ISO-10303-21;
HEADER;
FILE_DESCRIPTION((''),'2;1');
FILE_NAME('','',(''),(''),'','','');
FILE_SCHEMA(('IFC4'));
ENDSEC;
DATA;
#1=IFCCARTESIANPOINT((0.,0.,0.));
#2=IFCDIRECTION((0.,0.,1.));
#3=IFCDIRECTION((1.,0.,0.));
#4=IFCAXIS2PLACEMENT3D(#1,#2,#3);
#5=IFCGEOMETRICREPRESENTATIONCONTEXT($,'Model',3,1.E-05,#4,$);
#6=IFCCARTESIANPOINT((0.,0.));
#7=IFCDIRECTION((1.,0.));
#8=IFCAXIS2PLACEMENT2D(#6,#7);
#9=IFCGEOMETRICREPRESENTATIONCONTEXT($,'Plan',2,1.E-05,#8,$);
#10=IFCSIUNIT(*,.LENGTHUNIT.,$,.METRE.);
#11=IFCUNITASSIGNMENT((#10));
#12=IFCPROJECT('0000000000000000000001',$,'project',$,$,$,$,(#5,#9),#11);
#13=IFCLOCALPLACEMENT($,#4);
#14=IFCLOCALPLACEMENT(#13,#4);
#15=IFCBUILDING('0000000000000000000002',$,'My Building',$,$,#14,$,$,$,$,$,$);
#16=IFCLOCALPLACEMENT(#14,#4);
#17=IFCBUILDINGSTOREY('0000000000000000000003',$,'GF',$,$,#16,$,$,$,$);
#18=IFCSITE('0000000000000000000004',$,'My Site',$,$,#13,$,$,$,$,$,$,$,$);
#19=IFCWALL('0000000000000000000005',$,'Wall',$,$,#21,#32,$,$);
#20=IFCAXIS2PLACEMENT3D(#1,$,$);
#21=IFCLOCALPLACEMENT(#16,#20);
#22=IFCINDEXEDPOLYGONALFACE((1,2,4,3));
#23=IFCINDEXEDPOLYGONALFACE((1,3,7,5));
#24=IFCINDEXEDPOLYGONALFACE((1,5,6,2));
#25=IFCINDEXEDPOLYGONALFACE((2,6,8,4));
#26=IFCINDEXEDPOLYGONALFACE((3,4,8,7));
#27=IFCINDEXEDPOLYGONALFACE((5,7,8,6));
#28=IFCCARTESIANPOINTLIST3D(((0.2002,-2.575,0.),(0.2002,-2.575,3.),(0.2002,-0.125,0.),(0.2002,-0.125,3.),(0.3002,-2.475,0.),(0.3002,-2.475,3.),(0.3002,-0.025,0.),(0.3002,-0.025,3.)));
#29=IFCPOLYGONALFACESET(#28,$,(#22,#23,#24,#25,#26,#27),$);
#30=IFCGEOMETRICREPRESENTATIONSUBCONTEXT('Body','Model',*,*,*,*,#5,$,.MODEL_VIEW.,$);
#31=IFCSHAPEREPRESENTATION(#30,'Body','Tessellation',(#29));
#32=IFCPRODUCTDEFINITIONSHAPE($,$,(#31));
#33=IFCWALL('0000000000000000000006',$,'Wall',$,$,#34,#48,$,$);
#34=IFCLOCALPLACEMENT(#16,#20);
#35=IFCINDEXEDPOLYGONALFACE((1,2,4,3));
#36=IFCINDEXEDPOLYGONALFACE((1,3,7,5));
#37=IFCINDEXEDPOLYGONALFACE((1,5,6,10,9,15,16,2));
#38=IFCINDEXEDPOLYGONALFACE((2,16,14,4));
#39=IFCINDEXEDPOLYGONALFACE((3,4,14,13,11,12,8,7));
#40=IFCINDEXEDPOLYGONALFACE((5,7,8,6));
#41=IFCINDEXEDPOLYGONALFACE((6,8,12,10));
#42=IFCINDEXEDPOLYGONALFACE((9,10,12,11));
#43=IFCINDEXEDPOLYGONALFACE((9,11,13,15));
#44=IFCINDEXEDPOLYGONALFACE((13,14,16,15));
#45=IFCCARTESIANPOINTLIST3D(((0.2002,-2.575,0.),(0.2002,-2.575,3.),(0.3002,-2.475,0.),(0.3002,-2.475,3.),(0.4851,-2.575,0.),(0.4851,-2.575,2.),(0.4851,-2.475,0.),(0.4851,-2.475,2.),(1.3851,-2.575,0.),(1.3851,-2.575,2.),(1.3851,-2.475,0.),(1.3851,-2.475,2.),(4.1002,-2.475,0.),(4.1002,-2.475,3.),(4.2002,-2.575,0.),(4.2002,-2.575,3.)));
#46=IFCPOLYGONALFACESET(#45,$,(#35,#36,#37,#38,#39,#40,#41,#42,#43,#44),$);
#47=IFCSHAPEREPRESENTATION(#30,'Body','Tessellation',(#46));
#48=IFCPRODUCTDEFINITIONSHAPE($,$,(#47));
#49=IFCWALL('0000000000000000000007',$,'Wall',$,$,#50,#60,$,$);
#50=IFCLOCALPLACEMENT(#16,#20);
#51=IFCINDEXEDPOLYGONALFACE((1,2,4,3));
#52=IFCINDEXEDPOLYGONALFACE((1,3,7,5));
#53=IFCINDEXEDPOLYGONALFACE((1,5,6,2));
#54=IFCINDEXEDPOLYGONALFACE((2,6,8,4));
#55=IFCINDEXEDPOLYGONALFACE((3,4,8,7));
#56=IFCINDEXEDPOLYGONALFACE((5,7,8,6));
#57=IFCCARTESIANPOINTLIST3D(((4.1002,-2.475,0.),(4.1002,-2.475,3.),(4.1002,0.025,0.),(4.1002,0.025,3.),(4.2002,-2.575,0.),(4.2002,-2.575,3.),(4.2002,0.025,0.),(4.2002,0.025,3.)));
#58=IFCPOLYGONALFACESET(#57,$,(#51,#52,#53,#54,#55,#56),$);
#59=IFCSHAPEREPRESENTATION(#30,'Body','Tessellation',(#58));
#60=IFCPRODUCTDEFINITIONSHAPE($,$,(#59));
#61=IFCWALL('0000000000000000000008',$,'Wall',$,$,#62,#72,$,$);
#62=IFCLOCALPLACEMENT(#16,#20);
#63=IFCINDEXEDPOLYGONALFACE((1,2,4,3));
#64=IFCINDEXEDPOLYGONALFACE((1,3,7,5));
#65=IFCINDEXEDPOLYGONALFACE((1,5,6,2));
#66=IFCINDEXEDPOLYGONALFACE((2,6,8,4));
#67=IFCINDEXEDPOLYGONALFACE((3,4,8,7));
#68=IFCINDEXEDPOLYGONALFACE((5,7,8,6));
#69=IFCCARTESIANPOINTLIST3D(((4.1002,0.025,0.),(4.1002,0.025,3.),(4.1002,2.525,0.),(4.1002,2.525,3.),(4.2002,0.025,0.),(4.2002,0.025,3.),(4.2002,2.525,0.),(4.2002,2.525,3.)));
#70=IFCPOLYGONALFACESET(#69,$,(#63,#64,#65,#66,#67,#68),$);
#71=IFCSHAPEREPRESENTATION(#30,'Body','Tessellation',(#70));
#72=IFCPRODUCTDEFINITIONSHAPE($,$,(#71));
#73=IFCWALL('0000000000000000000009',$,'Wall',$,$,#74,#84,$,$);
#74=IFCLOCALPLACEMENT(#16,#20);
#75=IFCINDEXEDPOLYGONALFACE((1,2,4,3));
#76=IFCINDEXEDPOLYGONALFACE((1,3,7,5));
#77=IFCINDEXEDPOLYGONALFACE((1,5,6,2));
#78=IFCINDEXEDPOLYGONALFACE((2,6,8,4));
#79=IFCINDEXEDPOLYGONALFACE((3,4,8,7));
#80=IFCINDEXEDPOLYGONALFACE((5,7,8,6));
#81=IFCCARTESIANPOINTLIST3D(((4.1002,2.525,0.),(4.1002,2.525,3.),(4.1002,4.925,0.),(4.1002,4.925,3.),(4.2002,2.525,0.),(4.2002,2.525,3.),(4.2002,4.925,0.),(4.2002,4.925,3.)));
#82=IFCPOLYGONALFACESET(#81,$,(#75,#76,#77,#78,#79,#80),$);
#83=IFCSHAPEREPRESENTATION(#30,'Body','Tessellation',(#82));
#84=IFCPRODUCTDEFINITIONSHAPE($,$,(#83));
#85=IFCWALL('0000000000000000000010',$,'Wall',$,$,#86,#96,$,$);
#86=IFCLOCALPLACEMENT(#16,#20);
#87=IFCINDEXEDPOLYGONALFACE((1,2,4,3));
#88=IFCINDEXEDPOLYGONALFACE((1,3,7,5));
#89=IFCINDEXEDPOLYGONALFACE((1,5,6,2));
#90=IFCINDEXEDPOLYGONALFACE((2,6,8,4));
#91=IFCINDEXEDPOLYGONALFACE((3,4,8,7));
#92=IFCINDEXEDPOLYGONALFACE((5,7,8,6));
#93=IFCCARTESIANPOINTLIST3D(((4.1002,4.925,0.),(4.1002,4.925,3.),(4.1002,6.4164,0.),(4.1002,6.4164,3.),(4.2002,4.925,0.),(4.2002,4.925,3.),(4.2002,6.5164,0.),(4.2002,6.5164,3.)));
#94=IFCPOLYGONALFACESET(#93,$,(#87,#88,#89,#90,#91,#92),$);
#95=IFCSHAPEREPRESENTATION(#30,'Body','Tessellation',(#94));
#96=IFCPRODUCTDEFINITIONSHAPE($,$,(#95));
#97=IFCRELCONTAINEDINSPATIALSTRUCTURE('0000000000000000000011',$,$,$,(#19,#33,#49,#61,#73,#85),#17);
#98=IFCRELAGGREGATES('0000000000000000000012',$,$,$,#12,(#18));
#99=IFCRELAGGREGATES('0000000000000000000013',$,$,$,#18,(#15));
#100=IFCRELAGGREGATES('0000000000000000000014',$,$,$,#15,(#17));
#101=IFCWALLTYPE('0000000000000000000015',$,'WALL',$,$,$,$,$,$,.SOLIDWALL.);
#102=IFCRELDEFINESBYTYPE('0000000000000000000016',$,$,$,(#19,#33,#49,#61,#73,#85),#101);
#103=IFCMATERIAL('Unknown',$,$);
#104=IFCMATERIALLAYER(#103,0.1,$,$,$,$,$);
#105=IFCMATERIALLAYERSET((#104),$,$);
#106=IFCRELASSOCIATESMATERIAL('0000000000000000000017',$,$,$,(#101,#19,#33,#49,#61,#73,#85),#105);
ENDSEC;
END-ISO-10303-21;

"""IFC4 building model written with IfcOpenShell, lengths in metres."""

from ifc_helpers import new_model, si_unit, frame, origin_with_axes, origin_2d_with_axis, place, context, subcontext, project, spatial, line, indexed_curve, outline, extrude, source, transform, mapped, material, layer, layer_set, layer_usage, type_object, element, save


model = new_model("IFC4")

# Units and contexts
model_context = context("Model", 3, precision=1e-05, world=origin_with_axes())
plan_context = context("Plan", 2, precision=1e-05, world=origin_2d_with_axis())
body_context_1 = subcontext(model_context, "Body", "Model", "MODEL_VIEW")
ifc_project = project(units=[si_unit("LENGTHUNIT", "METRE")], contexts=[model_context, plan_context])

# Site, building, storey
site_placement = place(None, origin_with_axes())
site = spatial("IfcSite", under=ifc_project, at=site_placement, Name="My Site")
building_placement = place(site_placement, origin_with_axes())
building = spatial("IfcBuilding", under=site, at=building_placement, Name="My Building")
storey_placement = place(building_placement, origin_with_axes())
storey = spatial("IfcBuildingStorey", under=building, at=storey_placement, Name="GF")

# Shared definitions
ifc_material_1 = material(Name="Unknown")

# Shared definitions
ifc_layer_1 = layer(ifc_material_1, 0.1)
ifc_layer_set_1 = layer_set([ifc_layer_1])
wall_type = type_object("IfcWallType", Name="WALL", PredefinedType="SOLIDWALL", material=ifc_layer_set_1)

# Wall
ifc_layer_usage_1 = layer_usage(ifc_layer_set_1, "AXIS2", "POSITIVE", 0.0)
wall_1_placement = place(storey_placement, frame((0.2002, -0.125, 0.0), z_axis=(0.0, 0.0, 1.0), x_axis=(0.0, -1.0, 0.0)))
element("IfcWall", 1, at=wall_1_placement, inside=storey, type_object=wall_type, material=ifc_layer_usage_1, Name="Wall", context=body_context_1, shape_type="SweptSolid", body=[
    extrude(outline(indexed_curve([(0.0, 0.0), (-0.1, 0.1), (2.35, 0.1), (2.45, 0.0)], segments=[line(1, 2, 3, 4, 1)])), origin_with_axes(), (0.0, 0.0, 1.0), 3.0),
])

# Wall, opening
ifc_layer_usage_2 = layer_usage(ifc_layer_set_1, "AXIS2", "POSITIVE", 0.0)
wall_2_placement = place(storey_placement, frame((0.2002, -2.575, 0.0), z_axis=(0.0, 0.0, 1.0), x_axis=(1.0, 0.0, 0.0)))
wall_2 = element("IfcWall", 2, at=wall_2_placement, inside=storey, type_object=wall_type, material=ifc_layer_usage_2, Name="Wall", context=body_context_1, shape_type="SweptSolid", body=[
    extrude(outline(indexed_curve([(0.0, 0.0), (0.1, 0.1), (3.9, 0.1), (4.0, 0.0)], segments=[line(1, 2, 3, 4, 1)])), origin_with_axes(), (0.0, 0.0, 1.0), 3.0),
])
shared_shape_1 = source(origin_with_axes(), body_context_1, "Body", "SweptSolid", [
    extrude(outline(indexed_curve([(0.0, 0.0), (0.9, 0.0), (0.9, 2.0), (0.0, 2.0)], segments=[line(1, 2, 3, 4, 1)])), frame((0.0, -0.6, 0.0), z_axis=(0.0, -1.0, 0.0), x_axis=(1.0, 0.0, 0.0)), (0.0, 0.0, -1.0), 1.2),
])
opening_1_placement = place(wall_2_placement, frame((0.2849, 0.0, 0.0), z_axis=(0.0, 0.0, 1.0), x_axis=(1.0, 0.0, 0.0)))
element("IfcOpeningElement", 3, at=opening_1_placement, cuts=wall_2, PredefinedType="OPENING", context=body_context_1, shape_type="MappedRepresentation", body=[
    mapped(shared_shape_1, transform((0.0, 0.0, 0.0), x_axis=(1.0, 0.0, 0.0), y_axis=(0.0, 1.0, 0.0), z_axis=(0.0, 0.0, 1.0), scale=1.0)),
])

# Walls
ifc_layer_usage_3 = layer_usage(ifc_layer_set_1, "AXIS2", "POSITIVE", 0.0)
wall_3_placement = place(storey_placement, frame((4.2002, -2.575, 0.0), z_axis=(0.0, 0.0, 1.0), x_axis=(0.0, 1.0, 0.0)))
element("IfcWall", 4, at=wall_3_placement, inside=storey, type_object=wall_type, material=ifc_layer_usage_3, Name="Wall", context=body_context_1, shape_type="SweptSolid", body=[
    extrude(outline(indexed_curve([(0.0, 0.0), (0.1, 0.1), (2.6, 0.1), (2.6, 0.0)], segments=[line(1, 2, 3, 4, 1)])), origin_with_axes(), (0.0, 0.0, 1.0), 3.0),
])
ifc_layer_usage_4 = layer_usage(ifc_layer_set_1, "AXIS2", "POSITIVE", 0.0)
wall_4_placement = place(storey_placement, frame((4.2002, 0.025, 0.0), z_axis=(0.0, 0.0, 1.0), x_axis=(0.0, 1.0, 0.0)))
element("IfcWall", 5, at=wall_4_placement, inside=storey, type_object=wall_type, material=ifc_layer_usage_4, Name="Wall", context=body_context_1, shape_type="SweptSolid", body=[
    extrude(outline(indexed_curve([(0.0, 0.0), (0.0, 0.1), (2.5, 0.1), (2.5, 0.0)], segments=[line(1, 2, 3, 4, 1)])), origin_with_axes(), (0.0, 0.0, 1.0), 3.0),
])
ifc_layer_usage_5 = layer_usage(ifc_layer_set_1, "AXIS2", "POSITIVE", 0.0)
wall_5_placement = place(storey_placement, frame((4.2002, 2.525, 0.0), z_axis=(0.0, 0.0, 1.0), x_axis=(0.0, 1.0, 0.0)))
element("IfcWall", 6, at=wall_5_placement, inside=storey, type_object=wall_type, material=ifc_layer_usage_5, Name="Wall", context=body_context_1, shape_type="SweptSolid", body=[
    extrude(outline(indexed_curve([(0.0, 0.0), (0.0, 0.1), (2.4, 0.1), (2.4, 0.0)], segments=[line(1, 2, 3, 4, 1)])), origin_with_axes(), (0.0, 0.0, 1.0), 3.0),
])
ifc_layer_usage_6 = layer_usage(ifc_layer_set_1, "AXIS2", "POSITIVE", 0.0)
wall_6_placement = place(storey_placement, frame((4.2002, 4.925, 0.0), z_axis=(0.0, 0.0, 1.0), x_axis=(0.0, 1.0, 0.0)))
element("IfcWall", 7, at=wall_6_placement, inside=storey, type_object=wall_type, material=ifc_layer_usage_6, Name="Wall", context=body_context_1, shape_type="SweptSolid", body=[
    extrude(outline(indexed_curve([(0.0, 0.0), (0.0, 0.1), (1.4914, 0.1), (1.5914, 0.0)], segments=[line(1, 2, 3, 4, 1)])), origin_with_axes(), (0.0, 0.0, 1.0), 3.0),
])

save(model, "model.ifc")
